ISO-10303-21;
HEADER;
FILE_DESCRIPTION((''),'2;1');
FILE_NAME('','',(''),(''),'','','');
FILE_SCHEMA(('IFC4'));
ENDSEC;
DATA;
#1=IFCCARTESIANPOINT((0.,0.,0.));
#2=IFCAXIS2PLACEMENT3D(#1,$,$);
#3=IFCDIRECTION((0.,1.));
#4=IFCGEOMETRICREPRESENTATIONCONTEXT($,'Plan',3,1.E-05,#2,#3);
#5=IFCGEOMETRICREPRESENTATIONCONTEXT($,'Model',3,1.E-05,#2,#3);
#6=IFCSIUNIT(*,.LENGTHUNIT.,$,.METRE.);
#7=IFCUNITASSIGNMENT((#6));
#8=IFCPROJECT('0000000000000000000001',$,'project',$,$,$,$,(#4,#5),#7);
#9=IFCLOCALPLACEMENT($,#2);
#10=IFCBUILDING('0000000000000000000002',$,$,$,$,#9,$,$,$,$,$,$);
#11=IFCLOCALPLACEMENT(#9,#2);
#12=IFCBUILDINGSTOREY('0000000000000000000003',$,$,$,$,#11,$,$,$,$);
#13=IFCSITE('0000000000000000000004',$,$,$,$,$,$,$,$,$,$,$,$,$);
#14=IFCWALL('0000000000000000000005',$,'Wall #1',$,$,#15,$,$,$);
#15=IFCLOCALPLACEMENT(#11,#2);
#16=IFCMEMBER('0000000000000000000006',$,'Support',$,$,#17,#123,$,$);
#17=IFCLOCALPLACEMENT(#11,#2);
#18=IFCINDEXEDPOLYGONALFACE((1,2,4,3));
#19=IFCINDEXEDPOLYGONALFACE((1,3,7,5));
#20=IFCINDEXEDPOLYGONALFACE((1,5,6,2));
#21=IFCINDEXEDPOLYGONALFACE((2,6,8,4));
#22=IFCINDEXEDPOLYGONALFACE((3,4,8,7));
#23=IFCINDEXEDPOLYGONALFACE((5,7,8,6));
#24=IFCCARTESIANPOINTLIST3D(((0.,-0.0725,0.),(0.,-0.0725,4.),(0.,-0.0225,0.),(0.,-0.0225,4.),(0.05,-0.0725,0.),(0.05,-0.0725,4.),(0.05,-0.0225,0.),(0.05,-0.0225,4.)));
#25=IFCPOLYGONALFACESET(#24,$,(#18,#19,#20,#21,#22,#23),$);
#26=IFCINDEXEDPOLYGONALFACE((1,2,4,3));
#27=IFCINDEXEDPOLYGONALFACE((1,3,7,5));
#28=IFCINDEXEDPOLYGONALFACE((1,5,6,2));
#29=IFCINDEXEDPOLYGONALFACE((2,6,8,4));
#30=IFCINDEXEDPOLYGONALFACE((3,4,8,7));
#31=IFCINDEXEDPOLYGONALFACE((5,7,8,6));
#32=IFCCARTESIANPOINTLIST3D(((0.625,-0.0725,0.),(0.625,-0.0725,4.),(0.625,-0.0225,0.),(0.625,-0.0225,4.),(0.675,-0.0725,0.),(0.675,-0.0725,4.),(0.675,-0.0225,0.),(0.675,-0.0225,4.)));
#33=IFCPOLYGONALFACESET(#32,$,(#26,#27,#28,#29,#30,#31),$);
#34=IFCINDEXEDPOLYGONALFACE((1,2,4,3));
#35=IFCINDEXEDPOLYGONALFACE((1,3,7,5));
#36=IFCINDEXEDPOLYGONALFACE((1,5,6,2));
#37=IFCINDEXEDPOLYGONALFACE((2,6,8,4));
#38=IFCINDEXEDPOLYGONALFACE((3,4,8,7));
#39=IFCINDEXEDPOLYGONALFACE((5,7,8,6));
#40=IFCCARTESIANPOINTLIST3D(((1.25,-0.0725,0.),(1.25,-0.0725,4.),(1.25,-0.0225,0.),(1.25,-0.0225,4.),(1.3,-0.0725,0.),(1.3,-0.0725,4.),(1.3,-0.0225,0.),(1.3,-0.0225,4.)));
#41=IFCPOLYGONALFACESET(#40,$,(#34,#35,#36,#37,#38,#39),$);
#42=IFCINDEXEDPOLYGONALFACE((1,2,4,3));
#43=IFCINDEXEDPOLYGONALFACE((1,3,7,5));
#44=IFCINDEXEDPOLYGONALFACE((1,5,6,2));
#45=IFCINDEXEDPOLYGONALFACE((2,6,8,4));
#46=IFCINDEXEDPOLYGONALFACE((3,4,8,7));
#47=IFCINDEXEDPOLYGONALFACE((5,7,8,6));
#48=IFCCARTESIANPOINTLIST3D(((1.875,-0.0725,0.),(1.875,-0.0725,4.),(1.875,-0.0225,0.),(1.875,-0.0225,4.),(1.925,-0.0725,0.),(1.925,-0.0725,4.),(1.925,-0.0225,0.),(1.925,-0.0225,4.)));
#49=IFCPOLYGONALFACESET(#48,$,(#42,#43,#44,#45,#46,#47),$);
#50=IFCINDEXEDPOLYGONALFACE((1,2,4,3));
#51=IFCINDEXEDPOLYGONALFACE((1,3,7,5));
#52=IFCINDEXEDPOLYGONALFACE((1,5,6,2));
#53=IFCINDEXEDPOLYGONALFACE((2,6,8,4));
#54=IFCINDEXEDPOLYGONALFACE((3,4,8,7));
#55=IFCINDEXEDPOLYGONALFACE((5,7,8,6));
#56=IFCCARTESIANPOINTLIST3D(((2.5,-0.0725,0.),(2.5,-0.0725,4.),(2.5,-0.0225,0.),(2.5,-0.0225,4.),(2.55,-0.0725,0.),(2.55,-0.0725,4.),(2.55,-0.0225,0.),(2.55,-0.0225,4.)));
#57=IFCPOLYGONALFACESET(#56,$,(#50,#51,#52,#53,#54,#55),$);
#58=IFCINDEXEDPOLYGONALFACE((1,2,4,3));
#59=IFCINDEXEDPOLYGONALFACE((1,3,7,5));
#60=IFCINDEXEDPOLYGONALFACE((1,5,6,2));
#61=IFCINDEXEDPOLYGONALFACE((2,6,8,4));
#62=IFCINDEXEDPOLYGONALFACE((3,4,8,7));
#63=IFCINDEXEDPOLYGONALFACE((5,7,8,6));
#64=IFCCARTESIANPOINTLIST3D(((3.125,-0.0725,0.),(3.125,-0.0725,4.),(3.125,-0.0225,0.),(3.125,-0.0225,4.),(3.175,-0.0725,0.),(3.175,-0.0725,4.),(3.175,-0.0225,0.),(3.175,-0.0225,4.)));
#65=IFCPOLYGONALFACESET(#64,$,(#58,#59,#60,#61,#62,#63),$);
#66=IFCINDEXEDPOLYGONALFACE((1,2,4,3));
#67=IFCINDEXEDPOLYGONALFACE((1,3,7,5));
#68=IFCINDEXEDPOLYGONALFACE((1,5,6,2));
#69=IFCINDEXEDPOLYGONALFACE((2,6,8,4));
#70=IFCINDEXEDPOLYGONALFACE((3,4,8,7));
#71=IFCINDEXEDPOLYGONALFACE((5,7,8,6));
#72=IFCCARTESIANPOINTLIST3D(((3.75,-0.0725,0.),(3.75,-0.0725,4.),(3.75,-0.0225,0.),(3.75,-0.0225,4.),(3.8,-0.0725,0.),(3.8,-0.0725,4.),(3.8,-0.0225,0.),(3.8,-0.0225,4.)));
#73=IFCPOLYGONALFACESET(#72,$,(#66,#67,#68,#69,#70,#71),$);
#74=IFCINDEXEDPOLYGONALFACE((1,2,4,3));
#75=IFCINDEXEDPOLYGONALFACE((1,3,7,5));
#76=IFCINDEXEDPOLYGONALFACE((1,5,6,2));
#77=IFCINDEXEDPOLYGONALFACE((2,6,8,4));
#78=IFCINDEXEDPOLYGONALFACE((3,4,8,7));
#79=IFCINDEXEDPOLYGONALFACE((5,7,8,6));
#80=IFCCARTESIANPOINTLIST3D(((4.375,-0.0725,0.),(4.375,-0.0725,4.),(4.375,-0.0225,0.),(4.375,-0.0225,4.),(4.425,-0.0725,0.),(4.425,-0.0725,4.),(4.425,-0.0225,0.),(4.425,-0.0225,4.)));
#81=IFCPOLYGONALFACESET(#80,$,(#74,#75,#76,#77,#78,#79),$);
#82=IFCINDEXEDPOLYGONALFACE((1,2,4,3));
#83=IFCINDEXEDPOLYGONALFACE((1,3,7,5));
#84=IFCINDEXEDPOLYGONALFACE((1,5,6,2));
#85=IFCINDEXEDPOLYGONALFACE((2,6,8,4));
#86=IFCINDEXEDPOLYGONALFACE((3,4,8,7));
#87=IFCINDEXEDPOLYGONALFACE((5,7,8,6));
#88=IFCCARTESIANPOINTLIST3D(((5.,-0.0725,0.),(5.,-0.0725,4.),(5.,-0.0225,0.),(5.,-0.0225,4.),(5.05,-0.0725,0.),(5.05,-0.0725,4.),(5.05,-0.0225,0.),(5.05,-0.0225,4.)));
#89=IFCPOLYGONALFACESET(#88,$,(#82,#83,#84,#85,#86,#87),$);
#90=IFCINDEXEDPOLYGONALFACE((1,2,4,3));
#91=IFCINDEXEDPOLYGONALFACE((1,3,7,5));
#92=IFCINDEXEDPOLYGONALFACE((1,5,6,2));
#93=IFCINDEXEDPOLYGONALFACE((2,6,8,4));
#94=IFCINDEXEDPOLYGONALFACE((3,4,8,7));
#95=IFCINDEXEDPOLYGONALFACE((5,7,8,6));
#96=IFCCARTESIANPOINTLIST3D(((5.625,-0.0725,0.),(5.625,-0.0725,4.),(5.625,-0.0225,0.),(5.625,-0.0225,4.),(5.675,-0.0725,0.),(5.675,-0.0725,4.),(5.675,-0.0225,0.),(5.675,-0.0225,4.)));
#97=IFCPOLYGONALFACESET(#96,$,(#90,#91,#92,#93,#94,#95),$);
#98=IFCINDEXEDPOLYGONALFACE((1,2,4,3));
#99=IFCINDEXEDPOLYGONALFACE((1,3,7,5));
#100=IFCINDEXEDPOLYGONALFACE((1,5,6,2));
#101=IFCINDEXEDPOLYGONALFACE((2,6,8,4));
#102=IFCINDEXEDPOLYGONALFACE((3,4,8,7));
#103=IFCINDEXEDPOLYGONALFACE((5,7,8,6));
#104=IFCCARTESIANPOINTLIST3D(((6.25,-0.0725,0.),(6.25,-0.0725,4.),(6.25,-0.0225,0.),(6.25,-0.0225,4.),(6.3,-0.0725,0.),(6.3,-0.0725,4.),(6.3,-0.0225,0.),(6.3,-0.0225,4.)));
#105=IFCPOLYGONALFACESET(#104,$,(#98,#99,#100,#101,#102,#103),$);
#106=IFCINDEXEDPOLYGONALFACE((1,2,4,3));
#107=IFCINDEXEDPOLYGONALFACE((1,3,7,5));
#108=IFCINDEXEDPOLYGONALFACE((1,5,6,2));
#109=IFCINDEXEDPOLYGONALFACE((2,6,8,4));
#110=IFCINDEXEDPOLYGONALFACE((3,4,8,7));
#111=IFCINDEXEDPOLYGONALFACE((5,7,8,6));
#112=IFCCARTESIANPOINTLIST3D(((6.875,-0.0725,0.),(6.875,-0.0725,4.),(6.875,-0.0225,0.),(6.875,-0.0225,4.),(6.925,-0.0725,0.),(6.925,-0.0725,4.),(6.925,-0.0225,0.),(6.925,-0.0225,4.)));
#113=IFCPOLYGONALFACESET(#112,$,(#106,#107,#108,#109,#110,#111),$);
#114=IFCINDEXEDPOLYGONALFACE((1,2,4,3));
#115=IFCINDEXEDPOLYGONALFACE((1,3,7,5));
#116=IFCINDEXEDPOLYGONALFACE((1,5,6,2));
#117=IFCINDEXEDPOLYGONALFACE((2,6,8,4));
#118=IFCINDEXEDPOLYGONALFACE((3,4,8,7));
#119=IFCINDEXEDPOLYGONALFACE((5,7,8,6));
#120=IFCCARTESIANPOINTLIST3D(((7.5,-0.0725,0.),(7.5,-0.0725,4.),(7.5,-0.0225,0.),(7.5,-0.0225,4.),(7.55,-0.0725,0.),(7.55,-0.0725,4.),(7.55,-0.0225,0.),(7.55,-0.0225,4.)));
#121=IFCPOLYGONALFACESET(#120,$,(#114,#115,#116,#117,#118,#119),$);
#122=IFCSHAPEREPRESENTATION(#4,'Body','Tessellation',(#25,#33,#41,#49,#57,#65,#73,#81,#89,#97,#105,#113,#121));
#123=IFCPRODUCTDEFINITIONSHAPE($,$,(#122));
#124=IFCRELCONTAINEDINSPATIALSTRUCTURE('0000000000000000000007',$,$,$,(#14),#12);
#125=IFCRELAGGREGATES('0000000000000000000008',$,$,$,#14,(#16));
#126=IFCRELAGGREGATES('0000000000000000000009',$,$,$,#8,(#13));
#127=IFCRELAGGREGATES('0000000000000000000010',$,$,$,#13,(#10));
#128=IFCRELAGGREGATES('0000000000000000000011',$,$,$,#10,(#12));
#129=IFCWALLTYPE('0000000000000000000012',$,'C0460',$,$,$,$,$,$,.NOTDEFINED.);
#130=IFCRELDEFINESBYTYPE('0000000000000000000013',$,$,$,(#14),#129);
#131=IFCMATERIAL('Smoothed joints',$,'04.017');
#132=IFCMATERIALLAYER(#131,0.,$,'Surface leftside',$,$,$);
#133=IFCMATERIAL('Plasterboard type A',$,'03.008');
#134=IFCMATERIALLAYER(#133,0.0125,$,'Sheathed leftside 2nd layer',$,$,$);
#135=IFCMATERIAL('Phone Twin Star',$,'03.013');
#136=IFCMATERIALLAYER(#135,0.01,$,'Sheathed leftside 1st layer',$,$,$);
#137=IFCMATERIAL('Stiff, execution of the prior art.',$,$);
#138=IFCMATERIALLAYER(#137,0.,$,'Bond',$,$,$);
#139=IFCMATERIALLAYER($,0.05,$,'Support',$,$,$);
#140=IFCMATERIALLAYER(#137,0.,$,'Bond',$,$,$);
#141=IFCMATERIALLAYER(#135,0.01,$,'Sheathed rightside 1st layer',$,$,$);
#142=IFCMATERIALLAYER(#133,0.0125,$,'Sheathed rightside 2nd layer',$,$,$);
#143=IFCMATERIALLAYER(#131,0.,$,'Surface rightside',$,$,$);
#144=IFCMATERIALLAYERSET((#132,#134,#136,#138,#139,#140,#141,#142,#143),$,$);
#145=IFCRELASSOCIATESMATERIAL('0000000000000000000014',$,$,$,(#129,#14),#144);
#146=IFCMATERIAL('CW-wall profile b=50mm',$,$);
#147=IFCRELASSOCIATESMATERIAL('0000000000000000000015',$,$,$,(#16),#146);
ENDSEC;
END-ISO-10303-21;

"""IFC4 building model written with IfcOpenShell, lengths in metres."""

from ifc_helpers import new_model, si_unit, direction, frame, frame_2d, origin, place, context, project, spatial, rectangle, extrude, material, layer, layer_set, type_object, element, aggregate, save


model = new_model("IFC4")

# Units and contexts
plan_context = context("Plan", 3, precision=1e-05, world=origin(), true_north=direction((0.0, 1.0)))
model_context = context("Model", 3, precision=1e-05, world=origin(), true_north=direction((0.0, 1.0)))
ifc_project = project(units=[si_unit("LENGTHUNIT", "METRE")], contexts=[plan_context, model_context])

# Site, building, storey
site = spatial("IfcSite", under=ifc_project)
building_placement = place(None, origin())
building = spatial("IfcBuilding", under=site, at=building_placement)
storey_placement = place(building_placement, origin())
storey = spatial("IfcBuildingStorey", under=building, at=storey_placement)

# Wall, member
ifc_material_1 = material(Name="Smoothed joints", Category="04.017")
ifc_layer_1 = layer(ifc_material_1, 0.0, Name="Surface leftside")
ifc_material_2 = material(Name="Plasterboard type A", Category="03.008")
ifc_layer_2 = layer(ifc_material_2, 0.0125, Name="Sheathed leftside 2nd layer")
ifc_material_3 = material(Name="Phone Twin Star", Category="03.013")
ifc_layer_3 = layer(ifc_material_3, 0.01, Name="Sheathed leftside 1st layer")
ifc_material_4 = material(Name="Stiff, execution of the prior art.")
ifc_layer_4 = layer(ifc_material_4, 0.0, Name="Bond")
ifc_layer_5 = layer(None, 0.05, Name="Support")
ifc_layer_6 = layer(ifc_material_4, 0.0, Name="Bond")
ifc_layer_7 = layer(ifc_material_3, 0.01, Name="Sheathed rightside 1st layer")
ifc_layer_8 = layer(ifc_material_2, 0.0125, Name="Sheathed rightside 2nd layer")
ifc_layer_9 = layer(ifc_material_1, 0.0, Name="Surface rightside")
ifc_layer_set = layer_set([ifc_layer_1, ifc_layer_2, ifc_layer_3, ifc_layer_4, ifc_layer_5, ifc_layer_6, ifc_layer_7, ifc_layer_8, ifc_layer_9])
wall_type = type_object("IfcWallType", Name="C0460", PredefinedType="NOTDEFINED", material=ifc_layer_set)
wall_placement = place(None, frame((0.0, 0.0, 0.0), z_axis=(0.0, -1.0, 0.0), x_axis=(1.0, 0.0, 0.0)))
wall = element("IfcWall", 1, at=wall_placement, inside=storey, type_object=wall_type, material=ifc_layer_set, Name="Wall #1")
ifc_material_5 = material(Name="CW-wall profile b=50mm")
member_1_placement = place(wall_placement, origin())
member_1 = element("IfcMember", 2, at=member_1_placement, material=ifc_material_5, Name="Support", context=plan_context, shape_type="SweptSolid", body=[
    extrude(rectangle(XDim=0.05, YDim=0.05, at=frame_2d((0.025, 0.025), x_axis=(1.0, 0.0))), frame((0.0, 4.0, 0.0225), z_axis=(0.0, -1.0, 0.0), x_axis=(1.0, 0.0, 0.0)), (0.0, 0.0, 1.0), 4.0),
    extrude(rectangle(XDim=0.05, YDim=0.05, at=frame_2d((0.025, 0.025), x_axis=(1.0, 0.0))), frame((0.625, 4.0, 0.0225), z_axis=(0.0, -1.0, 0.0), x_axis=(1.0, 0.0, 0.0)), (0.0, 0.0, 1.0), 4.0),
    extrude(rectangle(XDim=0.05, YDim=0.05, at=frame_2d((0.025, 0.025), x_axis=(1.0, 0.0))), frame((1.25, 4.0, 0.0225), z_axis=(0.0, -1.0, 0.0), x_axis=(1.0, 0.0, 0.0)), (0.0, 0.0, 1.0), 4.0),
    extrude(rectangle(XDim=0.05, YDim=0.05, at=frame_2d((0.025, 0.025), x_axis=(1.0, 0.0))), frame((1.875, 4.0, 0.0225), z_axis=(0.0, -1.0, 0.0), x_axis=(1.0, 0.0, 0.0)), (0.0, 0.0, 1.0), 4.0),
    extrude(rectangle(XDim=0.05, YDim=0.05, at=frame_2d((0.025, 0.025), x_axis=(1.0, 0.0))), frame((2.5, 4.0, 0.0225), z_axis=(0.0, -1.0, 0.0), x_axis=(1.0, 0.0, 0.0)), (0.0, 0.0, 1.0), 4.0),
    extrude(rectangle(XDim=0.05, YDim=0.05, at=frame_2d((0.025, 0.025), x_axis=(1.0, 0.0))), frame((3.125, 4.0, 0.0225), z_axis=(0.0, -1.0, 0.0), x_axis=(1.0, 0.0, 0.0)), (0.0, 0.0, 1.0), 4.0),
    extrude(rectangle(XDim=0.05, YDim=0.05, at=frame_2d((0.025, 0.025), x_axis=(1.0, 0.0))), frame((3.75, 4.0, 0.0225), z_axis=(0.0, -1.0, 0.0), x_axis=(1.0, 0.0, 0.0)), (0.0, 0.0, 1.0), 4.0),
    extrude(rectangle(XDim=0.05, YDim=0.05, at=frame_2d((0.025, 0.025), x_axis=(1.0, 0.0))), frame((4.375, 4.0, 0.0225), z_axis=(0.0, -1.0, 0.0), x_axis=(1.0, 0.0, 0.0)), (0.0, 0.0, 1.0), 4.0),
    extrude(rectangle(XDim=0.05, YDim=0.05, at=frame_2d((0.025, 0.025), x_axis=(1.0, 0.0))), frame((5.0, 4.0, 0.0225), z_axis=(0.0, -1.0, 0.0), x_axis=(1.0, 0.0, 0.0)), (0.0, 0.0, 1.0), 4.0),
    extrude(rectangle(XDim=0.05, YDim=0.05, at=frame_2d((0.025, 0.025), x_axis=(1.0, 0.0))), frame((5.625, 4.0, 0.0225), z_axis=(0.0, -1.0, 0.0), x_axis=(1.0, 0.0, 0.0)), (0.0, 0.0, 1.0), 4.0),
    extrude(rectangle(XDim=0.05, YDim=0.05, at=frame_2d((0.025, 0.025), x_axis=(1.0, 0.0))), frame((6.25, 4.0, 0.0225), z_axis=(0.0, -1.0, 0.0), x_axis=(1.0, 0.0, 0.0)), (0.0, 0.0, 1.0), 4.0),
    extrude(rectangle(XDim=0.05, YDim=0.05, at=frame_2d((0.025, 0.025), x_axis=(1.0, 0.0))), frame((6.875, 4.0, 0.0225), z_axis=(0.0, -1.0, 0.0), x_axis=(1.0, 0.0, 0.0)), (0.0, 0.0, 1.0), 4.0),
    extrude(rectangle(XDim=0.05, YDim=0.05, at=frame_2d((0.025, 0.025), x_axis=(1.0, 0.0))), frame((7.5, 4.0, 0.0225), z_axis=(0.0, -1.0, 0.0), x_axis=(1.0, 0.0, 0.0)), (0.0, 0.0, 1.0), 4.0),
])
aggregate(wall, [member_1])

save(model, "model.ifc")
